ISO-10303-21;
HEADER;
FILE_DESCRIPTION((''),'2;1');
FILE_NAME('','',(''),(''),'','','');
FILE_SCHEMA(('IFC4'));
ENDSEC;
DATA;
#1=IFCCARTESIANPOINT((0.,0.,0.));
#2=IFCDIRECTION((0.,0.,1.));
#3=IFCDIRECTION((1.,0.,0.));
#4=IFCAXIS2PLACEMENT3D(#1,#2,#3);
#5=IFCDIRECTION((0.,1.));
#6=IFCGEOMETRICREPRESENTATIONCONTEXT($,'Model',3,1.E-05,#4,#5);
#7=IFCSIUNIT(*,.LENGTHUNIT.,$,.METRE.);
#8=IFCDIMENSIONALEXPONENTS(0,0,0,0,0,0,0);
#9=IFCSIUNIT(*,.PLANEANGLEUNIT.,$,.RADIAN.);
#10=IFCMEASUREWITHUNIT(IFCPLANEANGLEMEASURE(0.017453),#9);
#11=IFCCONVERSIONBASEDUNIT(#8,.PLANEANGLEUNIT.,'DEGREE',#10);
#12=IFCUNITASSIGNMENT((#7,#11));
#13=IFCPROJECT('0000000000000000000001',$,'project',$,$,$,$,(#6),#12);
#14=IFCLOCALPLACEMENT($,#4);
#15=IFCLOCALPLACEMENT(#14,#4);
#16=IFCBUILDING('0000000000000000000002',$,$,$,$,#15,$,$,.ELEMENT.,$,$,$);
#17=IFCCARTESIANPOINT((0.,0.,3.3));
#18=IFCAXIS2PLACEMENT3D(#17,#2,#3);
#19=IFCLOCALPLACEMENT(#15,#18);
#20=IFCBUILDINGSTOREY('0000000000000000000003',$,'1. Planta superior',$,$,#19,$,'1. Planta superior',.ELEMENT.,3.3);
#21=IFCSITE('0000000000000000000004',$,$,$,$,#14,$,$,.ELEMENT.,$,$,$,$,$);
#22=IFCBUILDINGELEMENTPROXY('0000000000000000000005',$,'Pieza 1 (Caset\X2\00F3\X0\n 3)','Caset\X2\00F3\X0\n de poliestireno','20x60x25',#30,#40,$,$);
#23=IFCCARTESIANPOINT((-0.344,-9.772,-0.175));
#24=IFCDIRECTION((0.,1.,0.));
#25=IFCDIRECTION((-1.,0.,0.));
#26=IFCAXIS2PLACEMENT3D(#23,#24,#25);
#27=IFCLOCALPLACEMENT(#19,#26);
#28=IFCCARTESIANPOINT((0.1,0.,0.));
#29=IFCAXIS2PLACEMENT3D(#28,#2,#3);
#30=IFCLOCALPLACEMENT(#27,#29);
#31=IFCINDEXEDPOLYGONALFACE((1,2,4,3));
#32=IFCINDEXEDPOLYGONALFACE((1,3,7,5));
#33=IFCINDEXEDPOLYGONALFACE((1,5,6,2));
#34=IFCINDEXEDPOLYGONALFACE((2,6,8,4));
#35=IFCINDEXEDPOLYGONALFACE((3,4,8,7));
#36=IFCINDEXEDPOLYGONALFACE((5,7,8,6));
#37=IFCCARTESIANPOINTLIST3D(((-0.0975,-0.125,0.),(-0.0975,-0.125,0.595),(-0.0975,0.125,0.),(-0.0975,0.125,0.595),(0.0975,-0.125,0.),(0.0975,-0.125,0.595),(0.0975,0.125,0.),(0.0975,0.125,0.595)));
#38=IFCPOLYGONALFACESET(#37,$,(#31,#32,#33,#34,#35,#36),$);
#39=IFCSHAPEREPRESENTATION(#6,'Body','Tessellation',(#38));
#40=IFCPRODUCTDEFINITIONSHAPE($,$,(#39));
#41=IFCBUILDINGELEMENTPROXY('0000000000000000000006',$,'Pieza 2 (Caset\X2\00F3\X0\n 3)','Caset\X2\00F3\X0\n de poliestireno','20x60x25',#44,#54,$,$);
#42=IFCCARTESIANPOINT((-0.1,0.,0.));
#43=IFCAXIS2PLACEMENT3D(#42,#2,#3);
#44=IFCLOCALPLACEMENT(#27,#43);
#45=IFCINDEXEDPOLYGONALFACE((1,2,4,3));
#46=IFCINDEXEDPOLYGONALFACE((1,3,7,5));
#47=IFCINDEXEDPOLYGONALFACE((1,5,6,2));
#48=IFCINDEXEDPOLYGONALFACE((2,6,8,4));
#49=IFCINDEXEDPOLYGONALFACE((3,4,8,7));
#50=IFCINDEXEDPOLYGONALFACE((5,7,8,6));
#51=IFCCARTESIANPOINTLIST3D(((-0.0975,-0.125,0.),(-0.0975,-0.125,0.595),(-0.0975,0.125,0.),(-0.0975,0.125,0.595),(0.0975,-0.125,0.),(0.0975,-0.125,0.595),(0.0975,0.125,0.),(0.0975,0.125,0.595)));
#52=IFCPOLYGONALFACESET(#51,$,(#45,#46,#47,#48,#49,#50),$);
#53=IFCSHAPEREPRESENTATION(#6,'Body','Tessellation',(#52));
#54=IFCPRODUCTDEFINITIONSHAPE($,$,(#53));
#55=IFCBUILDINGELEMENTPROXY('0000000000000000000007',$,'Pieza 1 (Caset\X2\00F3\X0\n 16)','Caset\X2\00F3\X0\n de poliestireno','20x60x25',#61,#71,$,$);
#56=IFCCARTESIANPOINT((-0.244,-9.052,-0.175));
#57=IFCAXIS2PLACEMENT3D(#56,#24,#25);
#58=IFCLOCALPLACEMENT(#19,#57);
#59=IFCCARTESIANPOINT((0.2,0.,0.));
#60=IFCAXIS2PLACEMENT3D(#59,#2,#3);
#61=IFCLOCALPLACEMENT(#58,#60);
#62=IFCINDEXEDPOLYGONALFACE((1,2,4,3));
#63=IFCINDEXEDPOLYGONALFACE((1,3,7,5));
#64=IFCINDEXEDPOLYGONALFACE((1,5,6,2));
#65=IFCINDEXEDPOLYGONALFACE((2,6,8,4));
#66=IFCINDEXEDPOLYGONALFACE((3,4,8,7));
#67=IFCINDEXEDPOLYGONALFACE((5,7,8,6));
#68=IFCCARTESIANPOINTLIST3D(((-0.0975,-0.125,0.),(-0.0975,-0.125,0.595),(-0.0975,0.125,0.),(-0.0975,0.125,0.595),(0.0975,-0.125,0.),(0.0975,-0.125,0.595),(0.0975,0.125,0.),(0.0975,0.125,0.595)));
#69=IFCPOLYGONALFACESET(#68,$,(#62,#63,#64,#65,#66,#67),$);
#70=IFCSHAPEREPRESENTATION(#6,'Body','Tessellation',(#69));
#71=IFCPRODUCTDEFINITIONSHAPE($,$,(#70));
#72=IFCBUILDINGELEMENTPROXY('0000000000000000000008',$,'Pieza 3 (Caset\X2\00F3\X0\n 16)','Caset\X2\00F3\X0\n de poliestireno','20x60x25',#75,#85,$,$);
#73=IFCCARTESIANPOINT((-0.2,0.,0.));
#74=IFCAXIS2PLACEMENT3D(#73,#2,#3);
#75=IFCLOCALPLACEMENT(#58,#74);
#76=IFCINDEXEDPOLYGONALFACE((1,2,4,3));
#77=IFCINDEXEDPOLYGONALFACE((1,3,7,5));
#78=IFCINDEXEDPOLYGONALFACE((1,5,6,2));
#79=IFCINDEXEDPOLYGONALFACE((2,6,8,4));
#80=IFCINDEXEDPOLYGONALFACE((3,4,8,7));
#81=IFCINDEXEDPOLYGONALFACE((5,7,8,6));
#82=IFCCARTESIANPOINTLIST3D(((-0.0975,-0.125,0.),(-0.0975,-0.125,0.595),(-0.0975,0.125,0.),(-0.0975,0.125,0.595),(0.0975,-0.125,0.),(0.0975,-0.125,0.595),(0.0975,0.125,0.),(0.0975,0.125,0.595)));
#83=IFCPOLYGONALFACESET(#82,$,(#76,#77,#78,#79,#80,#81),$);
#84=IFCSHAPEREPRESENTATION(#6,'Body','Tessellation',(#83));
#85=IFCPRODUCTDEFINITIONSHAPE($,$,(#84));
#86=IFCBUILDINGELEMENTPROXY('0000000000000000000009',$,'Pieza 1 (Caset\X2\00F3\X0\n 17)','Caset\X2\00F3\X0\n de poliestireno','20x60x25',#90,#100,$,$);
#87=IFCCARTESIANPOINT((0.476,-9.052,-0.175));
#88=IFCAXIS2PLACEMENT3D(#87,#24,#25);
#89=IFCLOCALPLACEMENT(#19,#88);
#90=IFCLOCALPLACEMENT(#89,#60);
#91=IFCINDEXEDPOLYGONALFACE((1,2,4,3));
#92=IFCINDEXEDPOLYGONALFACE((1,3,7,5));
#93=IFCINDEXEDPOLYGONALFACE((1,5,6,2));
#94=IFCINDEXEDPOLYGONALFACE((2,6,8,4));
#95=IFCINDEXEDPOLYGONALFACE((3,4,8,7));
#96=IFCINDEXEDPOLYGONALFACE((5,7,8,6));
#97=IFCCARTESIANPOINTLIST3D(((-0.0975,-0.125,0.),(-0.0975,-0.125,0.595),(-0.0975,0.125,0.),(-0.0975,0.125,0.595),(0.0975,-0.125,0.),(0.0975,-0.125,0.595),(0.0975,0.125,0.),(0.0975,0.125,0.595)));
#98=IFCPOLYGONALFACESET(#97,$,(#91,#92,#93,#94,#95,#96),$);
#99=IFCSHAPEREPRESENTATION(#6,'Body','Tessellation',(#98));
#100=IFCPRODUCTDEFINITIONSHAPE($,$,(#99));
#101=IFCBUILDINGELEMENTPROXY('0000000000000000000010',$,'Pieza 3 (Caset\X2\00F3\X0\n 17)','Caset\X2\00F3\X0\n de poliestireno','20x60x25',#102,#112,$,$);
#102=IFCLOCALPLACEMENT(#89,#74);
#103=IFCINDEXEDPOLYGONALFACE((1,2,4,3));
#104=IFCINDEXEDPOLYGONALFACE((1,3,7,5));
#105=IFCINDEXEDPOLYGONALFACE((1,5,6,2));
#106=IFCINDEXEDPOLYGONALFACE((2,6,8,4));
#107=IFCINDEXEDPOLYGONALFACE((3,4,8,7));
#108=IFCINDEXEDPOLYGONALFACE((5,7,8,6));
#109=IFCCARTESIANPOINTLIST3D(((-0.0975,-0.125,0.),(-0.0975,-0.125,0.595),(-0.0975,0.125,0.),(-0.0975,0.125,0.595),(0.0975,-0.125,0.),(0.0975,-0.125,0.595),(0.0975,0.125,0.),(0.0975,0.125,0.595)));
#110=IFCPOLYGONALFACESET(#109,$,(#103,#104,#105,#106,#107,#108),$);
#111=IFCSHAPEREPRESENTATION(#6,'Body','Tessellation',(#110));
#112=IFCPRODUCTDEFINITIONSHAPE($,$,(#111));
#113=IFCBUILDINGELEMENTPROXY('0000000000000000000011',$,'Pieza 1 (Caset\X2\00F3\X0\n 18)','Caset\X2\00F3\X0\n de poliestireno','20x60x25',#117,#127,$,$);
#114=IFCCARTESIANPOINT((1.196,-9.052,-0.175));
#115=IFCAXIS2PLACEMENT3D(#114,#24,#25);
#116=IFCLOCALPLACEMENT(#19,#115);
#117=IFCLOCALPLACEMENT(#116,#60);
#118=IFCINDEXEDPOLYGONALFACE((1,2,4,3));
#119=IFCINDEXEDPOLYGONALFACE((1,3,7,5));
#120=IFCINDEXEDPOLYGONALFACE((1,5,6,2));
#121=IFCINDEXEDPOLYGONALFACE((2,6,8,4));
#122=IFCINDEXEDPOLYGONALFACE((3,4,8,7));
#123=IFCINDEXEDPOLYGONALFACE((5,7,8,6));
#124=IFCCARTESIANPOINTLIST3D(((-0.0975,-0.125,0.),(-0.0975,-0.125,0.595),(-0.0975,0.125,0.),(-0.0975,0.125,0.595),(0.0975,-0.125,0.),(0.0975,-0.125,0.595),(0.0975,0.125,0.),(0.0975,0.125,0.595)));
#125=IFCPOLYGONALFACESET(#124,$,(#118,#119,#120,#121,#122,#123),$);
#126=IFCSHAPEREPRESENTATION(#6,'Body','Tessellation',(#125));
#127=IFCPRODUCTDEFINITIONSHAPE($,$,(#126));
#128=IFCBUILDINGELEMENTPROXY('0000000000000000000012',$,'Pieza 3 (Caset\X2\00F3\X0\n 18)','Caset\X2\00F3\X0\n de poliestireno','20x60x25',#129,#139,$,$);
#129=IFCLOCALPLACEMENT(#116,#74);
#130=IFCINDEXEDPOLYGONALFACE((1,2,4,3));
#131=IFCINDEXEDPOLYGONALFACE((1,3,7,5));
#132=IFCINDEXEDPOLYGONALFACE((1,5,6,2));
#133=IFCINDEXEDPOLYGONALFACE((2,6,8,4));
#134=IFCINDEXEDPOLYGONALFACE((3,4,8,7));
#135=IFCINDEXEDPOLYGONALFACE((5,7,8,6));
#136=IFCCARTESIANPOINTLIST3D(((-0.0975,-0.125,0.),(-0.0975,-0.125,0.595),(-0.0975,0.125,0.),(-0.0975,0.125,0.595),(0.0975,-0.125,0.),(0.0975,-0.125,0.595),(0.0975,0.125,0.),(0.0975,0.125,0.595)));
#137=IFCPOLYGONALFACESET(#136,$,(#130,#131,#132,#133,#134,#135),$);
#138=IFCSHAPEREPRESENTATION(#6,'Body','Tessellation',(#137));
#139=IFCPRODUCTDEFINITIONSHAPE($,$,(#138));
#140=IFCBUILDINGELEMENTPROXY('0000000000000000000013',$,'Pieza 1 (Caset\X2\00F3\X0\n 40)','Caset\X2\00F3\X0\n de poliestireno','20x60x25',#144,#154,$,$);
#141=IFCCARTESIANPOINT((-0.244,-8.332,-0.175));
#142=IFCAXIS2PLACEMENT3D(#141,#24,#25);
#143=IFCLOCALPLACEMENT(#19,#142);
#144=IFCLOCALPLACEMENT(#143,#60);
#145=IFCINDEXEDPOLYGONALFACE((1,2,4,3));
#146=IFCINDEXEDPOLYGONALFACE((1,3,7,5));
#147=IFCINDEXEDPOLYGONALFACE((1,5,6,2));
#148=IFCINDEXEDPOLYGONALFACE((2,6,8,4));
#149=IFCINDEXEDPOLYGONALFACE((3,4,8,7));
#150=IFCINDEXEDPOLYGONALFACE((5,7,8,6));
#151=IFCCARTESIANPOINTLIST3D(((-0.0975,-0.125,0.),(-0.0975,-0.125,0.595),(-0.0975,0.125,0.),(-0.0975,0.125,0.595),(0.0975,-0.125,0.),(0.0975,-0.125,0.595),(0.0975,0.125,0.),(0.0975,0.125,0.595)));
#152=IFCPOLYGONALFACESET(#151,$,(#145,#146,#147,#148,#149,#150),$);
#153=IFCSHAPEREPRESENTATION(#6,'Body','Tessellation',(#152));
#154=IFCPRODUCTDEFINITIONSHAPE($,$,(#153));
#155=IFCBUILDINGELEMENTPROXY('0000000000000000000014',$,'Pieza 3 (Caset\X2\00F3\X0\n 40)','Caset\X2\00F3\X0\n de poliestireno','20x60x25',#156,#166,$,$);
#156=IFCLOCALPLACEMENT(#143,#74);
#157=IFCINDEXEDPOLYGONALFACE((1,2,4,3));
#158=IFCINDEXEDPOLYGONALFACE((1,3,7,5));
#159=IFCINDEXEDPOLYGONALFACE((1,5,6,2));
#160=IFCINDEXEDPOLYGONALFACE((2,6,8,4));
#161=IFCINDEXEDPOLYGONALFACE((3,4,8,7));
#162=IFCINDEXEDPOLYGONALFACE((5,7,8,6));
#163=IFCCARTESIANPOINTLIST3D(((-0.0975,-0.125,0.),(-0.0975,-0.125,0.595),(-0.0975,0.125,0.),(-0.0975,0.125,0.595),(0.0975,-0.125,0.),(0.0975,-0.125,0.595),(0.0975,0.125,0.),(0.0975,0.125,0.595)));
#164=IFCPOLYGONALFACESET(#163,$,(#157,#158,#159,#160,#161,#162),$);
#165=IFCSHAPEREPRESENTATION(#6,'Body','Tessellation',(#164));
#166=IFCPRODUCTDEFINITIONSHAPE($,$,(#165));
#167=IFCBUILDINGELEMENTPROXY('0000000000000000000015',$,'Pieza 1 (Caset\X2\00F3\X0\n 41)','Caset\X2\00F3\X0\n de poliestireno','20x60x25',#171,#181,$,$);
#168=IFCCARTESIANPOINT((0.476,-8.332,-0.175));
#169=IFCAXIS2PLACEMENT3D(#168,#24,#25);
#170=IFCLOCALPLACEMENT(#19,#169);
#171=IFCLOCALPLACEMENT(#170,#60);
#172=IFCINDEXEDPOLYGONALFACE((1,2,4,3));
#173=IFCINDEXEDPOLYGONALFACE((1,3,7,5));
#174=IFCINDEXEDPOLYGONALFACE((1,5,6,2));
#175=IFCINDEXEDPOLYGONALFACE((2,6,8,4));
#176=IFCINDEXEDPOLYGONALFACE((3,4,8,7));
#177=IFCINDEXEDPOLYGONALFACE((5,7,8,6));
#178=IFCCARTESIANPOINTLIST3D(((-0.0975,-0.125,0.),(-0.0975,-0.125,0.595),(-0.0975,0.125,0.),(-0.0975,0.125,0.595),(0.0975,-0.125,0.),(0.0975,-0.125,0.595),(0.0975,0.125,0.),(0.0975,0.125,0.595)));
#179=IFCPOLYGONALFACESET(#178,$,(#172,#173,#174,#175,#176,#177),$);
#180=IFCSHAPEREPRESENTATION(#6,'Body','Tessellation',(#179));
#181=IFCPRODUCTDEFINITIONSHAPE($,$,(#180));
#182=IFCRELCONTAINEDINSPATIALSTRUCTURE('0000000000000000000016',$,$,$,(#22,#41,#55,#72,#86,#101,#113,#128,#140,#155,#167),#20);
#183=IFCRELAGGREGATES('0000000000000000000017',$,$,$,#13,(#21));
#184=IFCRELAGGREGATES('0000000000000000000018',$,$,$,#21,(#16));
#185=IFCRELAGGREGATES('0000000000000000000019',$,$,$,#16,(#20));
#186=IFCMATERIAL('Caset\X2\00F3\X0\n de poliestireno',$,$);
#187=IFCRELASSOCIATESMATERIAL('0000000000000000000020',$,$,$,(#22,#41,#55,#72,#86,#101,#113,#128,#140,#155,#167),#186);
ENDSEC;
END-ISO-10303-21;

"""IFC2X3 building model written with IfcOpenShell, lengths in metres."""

from ifc_helpers import new_model, entity, si_unit, converted_unit, direction, frame, origin_with_axes, origin_2d_with_axis, place, context, project, spatial, rectangle, extrude, source, transform, mapped, material, element, save


model = new_model("IFC2X3")

# Units and contexts
model_context = context("Model", 3, precision=1e-05, world=origin_with_axes(), true_north=direction((0.0, 1.0)))
ifc_project = project(units=[si_unit("LENGTHUNIT", "METRE"), converted_unit("PLANEANGLEUNIT", "DEGREE", entity("IfcPlaneAngleMeasure", 0.017453), si_unit("PLANEANGLEUNIT", "RADIAN"), dimensions=[0, 0, 0, 0, 0, 0, 0])], contexts=[model_context])

# Site, building, storey
site_placement = place(None, origin_with_axes())
site = spatial("IfcSite", under=ifc_project, at=site_placement, CompositionType="ELEMENT")
building_placement = place(site_placement, origin_with_axes())
building = spatial("IfcBuilding", under=site, at=building_placement, CompositionType="ELEMENT")
storey_placement = place(building_placement, frame((0.0, 0.0, 3.3), z_axis=(0.0, 0.0, 1.0), x_axis=(1.0, 0.0, 0.0)))
storey = spatial("IfcBuildingStorey", under=building, at=storey_placement, Name="1. Planta superior", LongName="1. Planta superior", CompositionType="ELEMENT", Elevation=3.3)

# Building element proxies
ifc_material_1 = material(Name="Casetón de poliestireno")
shared_shape = source(origin_with_axes(), model_context, "Body", "SweptSolid", [
    extrude(rectangle(XDim=0.195, YDim=0.25, at=origin_2d_with_axis()), origin_with_axes(), (0.0, 0.0, 1.0), 0.595),
])
placement_1 = place(storey_placement, frame((-0.344, -9.772, -0.175), z_axis=(0.0, 1.0, 0.0), x_axis=(-1.0, 0.0, 0.0)))
for number, where, z_axis, x_axis, name in (
    (1, (0.1, 0.0, 0.0), (0.0, 0.0, 1.0), (1.0, 0.0, 0.0), "Pieza 1 (Casetón 3)"),
    (2, (-0.1, 0.0, 0.0), (0.0, 0.0, 1.0), (1.0, 0.0, 0.0), "Pieza 2 (Casetón 3)"),
):
    element("IfcBuildingElementProxy", number, at=place(placement_1, frame(where, z_axis=z_axis, x_axis=x_axis)), inside=storey, material=ifc_material_1, Name=name, Description="Casetón de poliestireno", ObjectType="20x60x25", context=model_context, shape_type="MappedRepresentation", body=[
        mapped(shared_shape, transform((0.0, 0.0, 0.0), x_axis=(1.0, 0.0, 0.0), y_axis=(0.0, 1.0, 0.0), z_axis=(0.0, 0.0, 1.0))),
    ])
placement_2 = place(storey_placement, frame((-0.244, -9.052, -0.175), z_axis=(0.0, 1.0, 0.0), x_axis=(-1.0, 0.0, 0.0)))
for number, where, z_axis, x_axis, name in (
    (3, (0.2, 0.0, 0.0), (0.0, 0.0, 1.0), (1.0, 0.0, 0.0), "Pieza 1 (Casetón 16)"),
    (4, (-0.2, 0.0, 0.0), (0.0, 0.0, 1.0), (1.0, 0.0, 0.0), "Pieza 3 (Casetón 16)"),
):
    element("IfcBuildingElementProxy", number, at=place(placement_2, frame(where, z_axis=z_axis, x_axis=x_axis)), inside=storey, material=ifc_material_1, Name=name, Description="Casetón de poliestireno", ObjectType="20x60x25", context=model_context, shape_type="MappedRepresentation", body=[
        mapped(shared_shape, transform((0.0, 0.0, 0.0), x_axis=(1.0, 0.0, 0.0), y_axis=(0.0, 1.0, 0.0), z_axis=(0.0, 0.0, 1.0))),
    ])
placement_3 = place(storey_placement, frame((0.476, -9.052, -0.175), z_axis=(0.0, 1.0, 0.0), x_axis=(-1.0, 0.0, 0.0)))
for number, where, z_axis, x_axis, name in (
    (5, (0.2, 0.0, 0.0), (0.0, 0.0, 1.0), (1.0, 0.0, 0.0), "Pieza 1 (Casetón 17)"),
    (6, (-0.2, 0.0, 0.0), (0.0, 0.0, 1.0), (1.0, 0.0, 0.0), "Pieza 3 (Casetón 17)"),
):
    element("IfcBuildingElementProxy", number, at=place(placement_3, frame(where, z_axis=z_axis, x_axis=x_axis)), inside=storey, material=ifc_material_1, Name=name, Description="Casetón de poliestireno", ObjectType="20x60x25", context=model_context, shape_type="MappedRepresentation", body=[
        mapped(shared_shape, transform((0.0, 0.0, 0.0), x_axis=(1.0, 0.0, 0.0), y_axis=(0.0, 1.0, 0.0), z_axis=(0.0, 0.0, 1.0))),
    ])
placement_4 = place(storey_placement, frame((1.196, -9.052, -0.175), z_axis=(0.0, 1.0, 0.0), x_axis=(-1.0, 0.0, 0.0)))
for number, where, z_axis, x_axis, name in (
    (7, (0.2, 0.0, 0.0), (0.0, 0.0, 1.0), (1.0, 0.0, 0.0), "Pieza 1 (Casetón 18)"),
    (8, (-0.2, 0.0, 0.0), (0.0, 0.0, 1.0), (1.0, 0.0, 0.0), "Pieza 3 (Casetón 18)"),
):
    element("IfcBuildingElementProxy", number, at=place(placement_4, frame(where, z_axis=z_axis, x_axis=x_axis)), inside=storey, material=ifc_material_1, Name=name, Description="Casetón de poliestireno", ObjectType="20x60x25", context=model_context, shape_type="MappedRepresentation", body=[
        mapped(shared_shape, transform((0.0, 0.0, 0.0), x_axis=(1.0, 0.0, 0.0), y_axis=(0.0, 1.0, 0.0), z_axis=(0.0, 0.0, 1.0))),
    ])
placement_5 = place(storey_placement, frame((-0.244, -8.332, -0.175), z_axis=(0.0, 1.0, 0.0), x_axis=(-1.0, 0.0, 0.0)))
for number, where, z_axis, x_axis, name in (
    (9, (0.2, 0.0, 0.0), (0.0, 0.0, 1.0), (1.0, 0.0, 0.0), "Pieza 1 (Casetón 40)"),
    (10, (-0.2, 0.0, 0.0), (0.0, 0.0, 1.0), (1.0, 0.0, 0.0), "Pieza 3 (Casetón 40)"),
):
    element("IfcBuildingElementProxy", number, at=place(placement_5, frame(where, z_axis=z_axis, x_axis=x_axis)), inside=storey, material=ifc_material_1, Name=name, Description="Casetón de poliestireno", ObjectType="20x60x25", context=model_context, shape_type="MappedRepresentation", body=[
        mapped(shared_shape, transform((0.0, 0.0, 0.0), x_axis=(1.0, 0.0, 0.0), y_axis=(0.0, 1.0, 0.0), z_axis=(0.0, 0.0, 1.0))),
    ])
placement_6 = place(storey_placement, frame((0.476, -8.332, -0.175), z_axis=(0.0, 1.0, 0.0), x_axis=(-1.0, 0.0, 0.0)))
for number, where, z_axis, x_axis, name in (
    (11, (0.2, 0.0, 0.0), (0.0, 0.0, 1.0), (1.0, 0.0, 0.0), "Pieza 1 (Casetón 41)"),
):
    element("IfcBuildingElementProxy", number, at=place(placement_6, frame(where, z_axis=z_axis, x_axis=x_axis)), inside=storey, material=ifc_material_1, Name=name, Description="Casetón de poliestireno", ObjectType="20x60x25", context=model_context, shape_type="MappedRepresentation", body=[
        mapped(shared_shape, transform((0.0, 0.0, 0.0), x_axis=(1.0, 0.0, 0.0), y_axis=(0.0, 1.0, 0.0), z_axis=(0.0, 0.0, 1.0))),
    ])

save(model, "model.ifc")
